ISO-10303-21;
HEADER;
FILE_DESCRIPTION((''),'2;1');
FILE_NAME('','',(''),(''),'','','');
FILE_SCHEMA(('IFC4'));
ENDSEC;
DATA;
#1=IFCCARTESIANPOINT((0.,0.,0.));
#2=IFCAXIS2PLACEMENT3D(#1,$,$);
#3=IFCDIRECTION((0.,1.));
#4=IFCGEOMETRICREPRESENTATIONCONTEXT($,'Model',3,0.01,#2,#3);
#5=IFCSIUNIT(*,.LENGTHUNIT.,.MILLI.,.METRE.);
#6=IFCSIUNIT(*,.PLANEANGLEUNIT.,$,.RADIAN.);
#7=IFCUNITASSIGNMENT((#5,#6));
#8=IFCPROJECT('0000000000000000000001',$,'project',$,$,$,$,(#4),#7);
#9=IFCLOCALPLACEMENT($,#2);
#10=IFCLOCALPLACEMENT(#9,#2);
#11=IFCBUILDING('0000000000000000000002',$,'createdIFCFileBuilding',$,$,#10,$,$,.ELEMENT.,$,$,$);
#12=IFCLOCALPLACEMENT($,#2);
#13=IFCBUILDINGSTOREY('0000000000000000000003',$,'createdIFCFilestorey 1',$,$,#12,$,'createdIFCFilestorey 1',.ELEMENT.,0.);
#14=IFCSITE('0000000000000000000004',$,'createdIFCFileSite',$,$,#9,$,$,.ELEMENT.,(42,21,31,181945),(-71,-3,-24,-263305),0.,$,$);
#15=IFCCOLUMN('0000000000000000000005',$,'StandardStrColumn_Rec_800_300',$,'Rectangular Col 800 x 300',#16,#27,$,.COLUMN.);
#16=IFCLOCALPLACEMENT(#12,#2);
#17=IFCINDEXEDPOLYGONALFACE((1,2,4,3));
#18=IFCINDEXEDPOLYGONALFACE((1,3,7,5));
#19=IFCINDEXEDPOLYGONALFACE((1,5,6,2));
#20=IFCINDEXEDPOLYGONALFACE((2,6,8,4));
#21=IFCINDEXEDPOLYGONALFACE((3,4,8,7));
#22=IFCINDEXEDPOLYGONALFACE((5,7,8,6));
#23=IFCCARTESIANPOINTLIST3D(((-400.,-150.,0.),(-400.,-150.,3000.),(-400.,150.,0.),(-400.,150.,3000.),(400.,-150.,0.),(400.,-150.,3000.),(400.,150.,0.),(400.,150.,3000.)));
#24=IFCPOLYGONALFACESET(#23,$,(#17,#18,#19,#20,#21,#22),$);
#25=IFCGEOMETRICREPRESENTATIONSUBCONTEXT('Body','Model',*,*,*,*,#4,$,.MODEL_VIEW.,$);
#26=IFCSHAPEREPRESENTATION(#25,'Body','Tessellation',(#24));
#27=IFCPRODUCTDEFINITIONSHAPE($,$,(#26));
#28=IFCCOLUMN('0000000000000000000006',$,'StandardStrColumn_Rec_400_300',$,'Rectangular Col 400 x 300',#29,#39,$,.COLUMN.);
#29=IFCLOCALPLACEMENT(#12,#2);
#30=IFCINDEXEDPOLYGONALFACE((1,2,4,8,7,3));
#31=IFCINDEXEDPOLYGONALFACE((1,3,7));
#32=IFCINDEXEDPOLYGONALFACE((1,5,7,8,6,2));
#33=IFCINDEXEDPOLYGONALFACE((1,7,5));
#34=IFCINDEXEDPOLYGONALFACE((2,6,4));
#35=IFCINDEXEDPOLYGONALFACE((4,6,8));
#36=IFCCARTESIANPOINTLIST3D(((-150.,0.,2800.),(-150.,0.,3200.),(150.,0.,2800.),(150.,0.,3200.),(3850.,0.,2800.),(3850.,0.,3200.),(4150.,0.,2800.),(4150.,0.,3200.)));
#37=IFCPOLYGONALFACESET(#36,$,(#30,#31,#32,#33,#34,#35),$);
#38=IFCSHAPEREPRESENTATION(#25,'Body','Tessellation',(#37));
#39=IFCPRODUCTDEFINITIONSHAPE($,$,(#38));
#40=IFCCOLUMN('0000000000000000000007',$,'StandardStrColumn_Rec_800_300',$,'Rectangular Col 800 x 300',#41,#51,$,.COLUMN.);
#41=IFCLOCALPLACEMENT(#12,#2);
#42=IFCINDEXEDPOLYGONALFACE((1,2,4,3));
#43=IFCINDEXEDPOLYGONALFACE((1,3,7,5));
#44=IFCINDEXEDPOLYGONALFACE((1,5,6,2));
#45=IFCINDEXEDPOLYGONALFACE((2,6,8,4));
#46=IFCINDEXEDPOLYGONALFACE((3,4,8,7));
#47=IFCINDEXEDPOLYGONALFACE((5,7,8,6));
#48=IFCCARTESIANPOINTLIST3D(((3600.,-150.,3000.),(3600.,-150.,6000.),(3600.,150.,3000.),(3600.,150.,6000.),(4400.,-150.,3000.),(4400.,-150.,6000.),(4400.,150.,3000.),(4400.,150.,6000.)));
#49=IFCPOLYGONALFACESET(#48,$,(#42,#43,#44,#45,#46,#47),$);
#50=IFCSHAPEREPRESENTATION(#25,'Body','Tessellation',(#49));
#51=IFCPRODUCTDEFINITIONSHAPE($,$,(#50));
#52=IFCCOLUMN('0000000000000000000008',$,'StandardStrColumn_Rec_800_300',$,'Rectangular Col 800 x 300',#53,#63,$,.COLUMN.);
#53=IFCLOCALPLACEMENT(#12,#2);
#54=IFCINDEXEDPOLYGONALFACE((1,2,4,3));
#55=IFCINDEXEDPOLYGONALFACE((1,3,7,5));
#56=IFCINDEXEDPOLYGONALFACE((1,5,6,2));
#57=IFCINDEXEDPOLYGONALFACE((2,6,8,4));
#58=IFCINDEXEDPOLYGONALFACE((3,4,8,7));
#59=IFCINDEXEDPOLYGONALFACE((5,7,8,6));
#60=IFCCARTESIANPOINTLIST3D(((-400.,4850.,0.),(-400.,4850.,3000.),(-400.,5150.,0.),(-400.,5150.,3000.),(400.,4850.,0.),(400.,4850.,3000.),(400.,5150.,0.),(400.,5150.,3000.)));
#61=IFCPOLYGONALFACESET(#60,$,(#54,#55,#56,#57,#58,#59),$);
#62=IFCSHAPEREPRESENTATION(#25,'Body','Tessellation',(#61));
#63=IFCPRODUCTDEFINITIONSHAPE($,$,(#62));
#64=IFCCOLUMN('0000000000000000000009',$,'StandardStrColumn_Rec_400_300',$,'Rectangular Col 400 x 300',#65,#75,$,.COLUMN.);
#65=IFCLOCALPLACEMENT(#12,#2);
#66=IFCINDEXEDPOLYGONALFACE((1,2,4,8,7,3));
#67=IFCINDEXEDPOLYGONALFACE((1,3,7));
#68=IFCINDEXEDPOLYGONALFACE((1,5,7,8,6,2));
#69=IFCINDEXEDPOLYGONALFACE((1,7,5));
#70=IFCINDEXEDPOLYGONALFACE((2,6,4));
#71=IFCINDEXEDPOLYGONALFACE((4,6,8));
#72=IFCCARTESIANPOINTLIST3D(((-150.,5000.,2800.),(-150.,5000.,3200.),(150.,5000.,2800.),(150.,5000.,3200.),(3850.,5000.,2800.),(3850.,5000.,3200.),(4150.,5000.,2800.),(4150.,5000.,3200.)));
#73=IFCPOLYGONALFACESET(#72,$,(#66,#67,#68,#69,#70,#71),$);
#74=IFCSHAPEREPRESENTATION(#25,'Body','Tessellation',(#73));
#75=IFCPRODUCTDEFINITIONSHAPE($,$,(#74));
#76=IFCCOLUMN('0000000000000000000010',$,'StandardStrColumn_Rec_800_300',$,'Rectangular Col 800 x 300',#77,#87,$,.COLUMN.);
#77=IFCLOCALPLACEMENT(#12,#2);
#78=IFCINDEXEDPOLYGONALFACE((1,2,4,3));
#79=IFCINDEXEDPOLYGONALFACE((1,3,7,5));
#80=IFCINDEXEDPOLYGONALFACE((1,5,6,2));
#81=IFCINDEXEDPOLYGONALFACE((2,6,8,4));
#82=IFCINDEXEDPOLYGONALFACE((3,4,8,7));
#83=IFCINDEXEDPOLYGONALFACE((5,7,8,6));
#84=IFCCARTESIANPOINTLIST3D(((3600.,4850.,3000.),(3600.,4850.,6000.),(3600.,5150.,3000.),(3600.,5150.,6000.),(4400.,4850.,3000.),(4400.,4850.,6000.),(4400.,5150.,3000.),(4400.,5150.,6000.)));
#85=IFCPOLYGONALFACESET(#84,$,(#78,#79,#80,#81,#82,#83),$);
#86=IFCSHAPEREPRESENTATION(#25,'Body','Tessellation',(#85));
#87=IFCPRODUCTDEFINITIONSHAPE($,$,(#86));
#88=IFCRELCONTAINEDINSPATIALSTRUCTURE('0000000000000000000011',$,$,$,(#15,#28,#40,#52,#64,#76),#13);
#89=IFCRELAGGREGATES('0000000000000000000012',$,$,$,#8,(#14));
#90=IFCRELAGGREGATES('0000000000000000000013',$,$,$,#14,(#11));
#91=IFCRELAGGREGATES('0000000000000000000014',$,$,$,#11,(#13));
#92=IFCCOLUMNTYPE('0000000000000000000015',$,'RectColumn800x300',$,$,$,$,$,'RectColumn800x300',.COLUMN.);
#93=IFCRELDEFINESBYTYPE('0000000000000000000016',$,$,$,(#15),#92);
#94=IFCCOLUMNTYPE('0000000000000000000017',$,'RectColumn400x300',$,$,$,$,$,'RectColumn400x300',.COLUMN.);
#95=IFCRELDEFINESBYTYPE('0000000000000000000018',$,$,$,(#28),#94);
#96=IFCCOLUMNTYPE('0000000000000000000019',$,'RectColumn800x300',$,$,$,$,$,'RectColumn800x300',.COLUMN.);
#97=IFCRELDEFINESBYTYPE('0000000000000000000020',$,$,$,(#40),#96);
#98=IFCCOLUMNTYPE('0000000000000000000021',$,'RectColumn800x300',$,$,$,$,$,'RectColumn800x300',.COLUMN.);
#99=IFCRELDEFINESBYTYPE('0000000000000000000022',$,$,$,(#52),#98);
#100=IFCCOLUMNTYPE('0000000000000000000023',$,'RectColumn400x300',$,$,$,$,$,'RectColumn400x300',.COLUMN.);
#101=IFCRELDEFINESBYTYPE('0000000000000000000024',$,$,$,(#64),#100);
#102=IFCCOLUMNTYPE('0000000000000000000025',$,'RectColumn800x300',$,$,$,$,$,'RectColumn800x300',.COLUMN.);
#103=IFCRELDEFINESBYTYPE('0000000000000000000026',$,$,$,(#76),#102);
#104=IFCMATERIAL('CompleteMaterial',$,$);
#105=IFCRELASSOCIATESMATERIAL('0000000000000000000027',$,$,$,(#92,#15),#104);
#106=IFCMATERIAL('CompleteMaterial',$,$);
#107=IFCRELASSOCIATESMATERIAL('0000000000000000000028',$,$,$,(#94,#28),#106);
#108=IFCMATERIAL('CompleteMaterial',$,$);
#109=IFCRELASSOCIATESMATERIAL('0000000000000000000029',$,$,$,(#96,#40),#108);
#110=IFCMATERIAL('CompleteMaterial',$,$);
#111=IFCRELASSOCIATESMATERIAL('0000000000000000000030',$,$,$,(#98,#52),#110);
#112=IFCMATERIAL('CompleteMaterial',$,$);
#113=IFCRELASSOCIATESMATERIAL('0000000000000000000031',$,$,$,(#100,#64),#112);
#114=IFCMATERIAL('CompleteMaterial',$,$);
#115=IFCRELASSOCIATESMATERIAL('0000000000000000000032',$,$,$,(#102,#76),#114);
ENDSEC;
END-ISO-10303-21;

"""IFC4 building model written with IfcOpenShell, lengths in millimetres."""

from ifc_helpers import new_model, si_unit, direction, frame, frame_2d, origin, place, context, subcontext, project, spatial, rectangle, extrude, source, transform, mapped, material, type_object, type_shapes, element, save


model = new_model("IFC4")

# Units and contexts
model_context = context("Model", 3, precision=0.01, world=origin(), true_north=direction((0.0, 1.0)))
body_context = subcontext(model_context, "Body", "Model", "MODEL_VIEW")
ifc_project = project(units=[si_unit("LENGTHUNIT", "METRE", prefix="MILLI"), si_unit("PLANEANGLEUNIT", "RADIAN")], contexts=[model_context])

# Site, building, storey
site_placement = place(None, origin())
site = spatial("IfcSite", under=ifc_project, at=site_placement, Name="createdIFCFileSite", CompositionType="ELEMENT", RefLatitude=(42, 21, 31, 181945), RefLongitude=(-71, -3, -24, -263305), RefElevation=0.0)
building_placement = place(site_placement, origin())
building = spatial("IfcBuilding", under=site, at=building_placement, Name="createdIFCFileBuilding", CompositionType="ELEMENT")
storey_placement = place(None, origin())
storey = spatial("IfcBuildingStorey", under=building, at=storey_placement, Name="createdIFCFilestorey 1", LongName="createdIFCFilestorey 1", CompositionType="ELEMENT", Elevation=0.0)

# Columns
ifc_material_1 = material(Name="CompleteMaterial")
column_type_1 = type_object("IfcColumnType", Name="RectColumn800x300", ElementType="RectColumn800x300", PredefinedType="COLUMN", material=ifc_material_1)
shared_shape_1 = source(origin(), body_context, "Body", "SweptSolid", [
    extrude(rectangle(XDim=300.0, YDim=800.0, at=frame_2d((0.0, 0.0, 0.0), x_axis=(1.0, 0.0, 0.0))), frame((0.0, 0.0, 0.0), z_axis=(0.0, 0.0, 1.0), x_axis=(0.0, -1.0, 0.0)), (0.0, 0.0, 1.0), 3000.0),
])
type_shapes(column_type_1, [shared_shape_1])
column_1_placement = place(None, origin())
element("IfcColumn", 1, at=column_1_placement, inside=storey, type_object=column_type_1, material=ifc_material_1, Name="StandardStrColumn_Rec_800_300", ObjectType="Rectangular Col 800 x 300", PredefinedType="COLUMN", context=body_context, shape_type="MappedRepresentation", body=[
    mapped(shared_shape_1, transform((0.0, 0.0, 0.0), scale=1.0)),
])
ifc_material_2 = material(Name="CompleteMaterial")
column_type_2 = type_object("IfcColumnType", Name="RectColumn400x300", ElementType="RectColumn400x300", PredefinedType="COLUMN", material=ifc_material_2)
shared_shape_2 = source(origin(), body_context, "Body", "SweptSolid", [
    extrude(rectangle(XDim=300.0, YDim=400.0, at=frame_2d((0.0, 0.0, 0.0), x_axis=(0.0, 1.0, 0.0))), frame((0.0, 0.0, 0.0), z_axis=(0.0, 1.0, 0.0), x_axis=(0.0, 0.0, 1.0)), (0.0, 1.0, 0.0), 4000.0),
])
type_shapes(column_type_2, [shared_shape_2])
column_2_placement = place(None, frame((0.0, 0.0, 3000.0)))
element("IfcColumn", 2, at=column_2_placement, inside=storey, type_object=column_type_2, material=ifc_material_2, Name="StandardStrColumn_Rec_400_300", ObjectType="Rectangular Col 400 x 300", PredefinedType="COLUMN", context=body_context, shape_type="MappedRepresentation", body=[
    mapped(shared_shape_2, transform((0.0, 0.0, 0.0), scale=1.0)),
])
ifc_material_3 = material(Name="CompleteMaterial")
column_type_3 = type_object("IfcColumnType", Name="RectColumn800x300", ElementType="RectColumn800x300", PredefinedType="COLUMN", material=ifc_material_3)
shared_shape_3 = source(origin(), body_context, "Body", "SweptSolid", [
    extrude(rectangle(XDim=300.0, YDim=800.0, at=frame_2d((0.0, 0.0, 0.0), x_axis=(1.0, 0.0, 0.0))), frame((0.0, 0.0, 0.0), z_axis=(0.0, 0.0, 1.0), x_axis=(0.0, -1.0, 0.0)), (0.0, 0.0, 1.0), 3000.0),
])
type_shapes(column_type_3, [shared_shape_3])
column_3_placement = place(None, frame((4000.0, 0.0, 3000.0)))
element("IfcColumn", 3, at=column_3_placement, inside=storey, type_object=column_type_3, material=ifc_material_3, Name="StandardStrColumn_Rec_800_300", ObjectType="Rectangular Col 800 x 300", PredefinedType="COLUMN", context=body_context, shape_type="MappedRepresentation", body=[
    mapped(shared_shape_3, transform((0.0, 0.0, 0.0), scale=1.0)),
])
ifc_material_4 = material(Name="CompleteMaterial")
column_type_4 = type_object("IfcColumnType", Name="RectColumn800x300", ElementType="RectColumn800x300", PredefinedType="COLUMN", material=ifc_material_4)
shared_shape_4 = source(origin(), body_context, "Body", "SweptSolid", [
    extrude(rectangle(XDim=300.0, YDim=800.0, at=frame_2d((0.0, 0.0, 0.0), x_axis=(1.0, 0.0, 0.0))), frame((0.0, 0.0, 0.0), z_axis=(0.0, 0.0, 1.0), x_axis=(0.0, -1.0, 0.0)), (0.0, 0.0, 1.0), 3000.0),
])
type_shapes(column_type_4, [shared_shape_4])
column_4_placement = place(None, frame((0.0, 5000.0, 0.0)))
element("IfcColumn", 4, at=column_4_placement, inside=storey, type_object=column_type_4, material=ifc_material_4, Name="StandardStrColumn_Rec_800_300", ObjectType="Rectangular Col 800 x 300", PredefinedType="COLUMN", context=body_context, shape_type="MappedRepresentation", body=[
    mapped(shared_shape_4, transform((0.0, 0.0, 0.0), scale=1.0)),
])
ifc_material_5 = material(Name="CompleteMaterial")
column_type_5 = type_object("IfcColumnType", Name="RectColumn400x300", ElementType="RectColumn400x300", PredefinedType="COLUMN", material=ifc_material_5)
shared_shape_5 = source(origin(), body_context, "Body", "SweptSolid", [
    extrude(rectangle(XDim=300.0, YDim=400.0, at=frame_2d((0.0, 0.0, 0.0), x_axis=(0.0, 1.0, 0.0))), frame((0.0, 0.0, 0.0), z_axis=(0.0, 1.0, 0.0), x_axis=(0.0, 0.0, 1.0)), (0.0, 1.0, 0.0), 4000.0),
])
type_shapes(column_type_5, [shared_shape_5])
column_5_placement = place(None, frame((0.0, 5000.0, 3000.0)))
element("IfcColumn", 5, at=column_5_placement, inside=storey, type_object=column_type_5, material=ifc_material_5, Name="StandardStrColumn_Rec_400_300", ObjectType="Rectangular Col 400 x 300", PredefinedType="COLUMN", context=body_context, shape_type="MappedRepresentation", body=[
    mapped(shared_shape_5, transform((0.0, 0.0, 0.0), scale=1.0)),
])
ifc_material_6 = material(Name="CompleteMaterial")
column_type_6 = type_object("IfcColumnType", Name="RectColumn800x300", ElementType="RectColumn800x300", PredefinedType="COLUMN", material=ifc_material_6)
shared_shape_6 = source(origin(), body_context, "Body", "SweptSolid", [
    extrude(rectangle(XDim=300.0, YDim=800.0, at=frame_2d((0.0, 0.0, 0.0), x_axis=(1.0, 0.0, 0.0))), frame((0.0, 0.0, 0.0), z_axis=(0.0, 0.0, 1.0), x_axis=(0.0, -1.0, 0.0)), (0.0, 0.0, 1.0), 3000.0),
])
type_shapes(column_type_6, [shared_shape_6])
column_6_placement = place(None, frame((4000.0, 5000.0, 3000.0)))
element("IfcColumn", 6, at=column_6_placement, inside=storey, type_object=column_type_6, material=ifc_material_6, Name="StandardStrColumn_Rec_800_300", ObjectType="Rectangular Col 800 x 300", PredefinedType="COLUMN", context=body_context, shape_type="MappedRepresentation", body=[
    mapped(shared_shape_6, transform((0.0, 0.0, 0.0), scale=1.0)),
])

save(model, "model.ifc")
